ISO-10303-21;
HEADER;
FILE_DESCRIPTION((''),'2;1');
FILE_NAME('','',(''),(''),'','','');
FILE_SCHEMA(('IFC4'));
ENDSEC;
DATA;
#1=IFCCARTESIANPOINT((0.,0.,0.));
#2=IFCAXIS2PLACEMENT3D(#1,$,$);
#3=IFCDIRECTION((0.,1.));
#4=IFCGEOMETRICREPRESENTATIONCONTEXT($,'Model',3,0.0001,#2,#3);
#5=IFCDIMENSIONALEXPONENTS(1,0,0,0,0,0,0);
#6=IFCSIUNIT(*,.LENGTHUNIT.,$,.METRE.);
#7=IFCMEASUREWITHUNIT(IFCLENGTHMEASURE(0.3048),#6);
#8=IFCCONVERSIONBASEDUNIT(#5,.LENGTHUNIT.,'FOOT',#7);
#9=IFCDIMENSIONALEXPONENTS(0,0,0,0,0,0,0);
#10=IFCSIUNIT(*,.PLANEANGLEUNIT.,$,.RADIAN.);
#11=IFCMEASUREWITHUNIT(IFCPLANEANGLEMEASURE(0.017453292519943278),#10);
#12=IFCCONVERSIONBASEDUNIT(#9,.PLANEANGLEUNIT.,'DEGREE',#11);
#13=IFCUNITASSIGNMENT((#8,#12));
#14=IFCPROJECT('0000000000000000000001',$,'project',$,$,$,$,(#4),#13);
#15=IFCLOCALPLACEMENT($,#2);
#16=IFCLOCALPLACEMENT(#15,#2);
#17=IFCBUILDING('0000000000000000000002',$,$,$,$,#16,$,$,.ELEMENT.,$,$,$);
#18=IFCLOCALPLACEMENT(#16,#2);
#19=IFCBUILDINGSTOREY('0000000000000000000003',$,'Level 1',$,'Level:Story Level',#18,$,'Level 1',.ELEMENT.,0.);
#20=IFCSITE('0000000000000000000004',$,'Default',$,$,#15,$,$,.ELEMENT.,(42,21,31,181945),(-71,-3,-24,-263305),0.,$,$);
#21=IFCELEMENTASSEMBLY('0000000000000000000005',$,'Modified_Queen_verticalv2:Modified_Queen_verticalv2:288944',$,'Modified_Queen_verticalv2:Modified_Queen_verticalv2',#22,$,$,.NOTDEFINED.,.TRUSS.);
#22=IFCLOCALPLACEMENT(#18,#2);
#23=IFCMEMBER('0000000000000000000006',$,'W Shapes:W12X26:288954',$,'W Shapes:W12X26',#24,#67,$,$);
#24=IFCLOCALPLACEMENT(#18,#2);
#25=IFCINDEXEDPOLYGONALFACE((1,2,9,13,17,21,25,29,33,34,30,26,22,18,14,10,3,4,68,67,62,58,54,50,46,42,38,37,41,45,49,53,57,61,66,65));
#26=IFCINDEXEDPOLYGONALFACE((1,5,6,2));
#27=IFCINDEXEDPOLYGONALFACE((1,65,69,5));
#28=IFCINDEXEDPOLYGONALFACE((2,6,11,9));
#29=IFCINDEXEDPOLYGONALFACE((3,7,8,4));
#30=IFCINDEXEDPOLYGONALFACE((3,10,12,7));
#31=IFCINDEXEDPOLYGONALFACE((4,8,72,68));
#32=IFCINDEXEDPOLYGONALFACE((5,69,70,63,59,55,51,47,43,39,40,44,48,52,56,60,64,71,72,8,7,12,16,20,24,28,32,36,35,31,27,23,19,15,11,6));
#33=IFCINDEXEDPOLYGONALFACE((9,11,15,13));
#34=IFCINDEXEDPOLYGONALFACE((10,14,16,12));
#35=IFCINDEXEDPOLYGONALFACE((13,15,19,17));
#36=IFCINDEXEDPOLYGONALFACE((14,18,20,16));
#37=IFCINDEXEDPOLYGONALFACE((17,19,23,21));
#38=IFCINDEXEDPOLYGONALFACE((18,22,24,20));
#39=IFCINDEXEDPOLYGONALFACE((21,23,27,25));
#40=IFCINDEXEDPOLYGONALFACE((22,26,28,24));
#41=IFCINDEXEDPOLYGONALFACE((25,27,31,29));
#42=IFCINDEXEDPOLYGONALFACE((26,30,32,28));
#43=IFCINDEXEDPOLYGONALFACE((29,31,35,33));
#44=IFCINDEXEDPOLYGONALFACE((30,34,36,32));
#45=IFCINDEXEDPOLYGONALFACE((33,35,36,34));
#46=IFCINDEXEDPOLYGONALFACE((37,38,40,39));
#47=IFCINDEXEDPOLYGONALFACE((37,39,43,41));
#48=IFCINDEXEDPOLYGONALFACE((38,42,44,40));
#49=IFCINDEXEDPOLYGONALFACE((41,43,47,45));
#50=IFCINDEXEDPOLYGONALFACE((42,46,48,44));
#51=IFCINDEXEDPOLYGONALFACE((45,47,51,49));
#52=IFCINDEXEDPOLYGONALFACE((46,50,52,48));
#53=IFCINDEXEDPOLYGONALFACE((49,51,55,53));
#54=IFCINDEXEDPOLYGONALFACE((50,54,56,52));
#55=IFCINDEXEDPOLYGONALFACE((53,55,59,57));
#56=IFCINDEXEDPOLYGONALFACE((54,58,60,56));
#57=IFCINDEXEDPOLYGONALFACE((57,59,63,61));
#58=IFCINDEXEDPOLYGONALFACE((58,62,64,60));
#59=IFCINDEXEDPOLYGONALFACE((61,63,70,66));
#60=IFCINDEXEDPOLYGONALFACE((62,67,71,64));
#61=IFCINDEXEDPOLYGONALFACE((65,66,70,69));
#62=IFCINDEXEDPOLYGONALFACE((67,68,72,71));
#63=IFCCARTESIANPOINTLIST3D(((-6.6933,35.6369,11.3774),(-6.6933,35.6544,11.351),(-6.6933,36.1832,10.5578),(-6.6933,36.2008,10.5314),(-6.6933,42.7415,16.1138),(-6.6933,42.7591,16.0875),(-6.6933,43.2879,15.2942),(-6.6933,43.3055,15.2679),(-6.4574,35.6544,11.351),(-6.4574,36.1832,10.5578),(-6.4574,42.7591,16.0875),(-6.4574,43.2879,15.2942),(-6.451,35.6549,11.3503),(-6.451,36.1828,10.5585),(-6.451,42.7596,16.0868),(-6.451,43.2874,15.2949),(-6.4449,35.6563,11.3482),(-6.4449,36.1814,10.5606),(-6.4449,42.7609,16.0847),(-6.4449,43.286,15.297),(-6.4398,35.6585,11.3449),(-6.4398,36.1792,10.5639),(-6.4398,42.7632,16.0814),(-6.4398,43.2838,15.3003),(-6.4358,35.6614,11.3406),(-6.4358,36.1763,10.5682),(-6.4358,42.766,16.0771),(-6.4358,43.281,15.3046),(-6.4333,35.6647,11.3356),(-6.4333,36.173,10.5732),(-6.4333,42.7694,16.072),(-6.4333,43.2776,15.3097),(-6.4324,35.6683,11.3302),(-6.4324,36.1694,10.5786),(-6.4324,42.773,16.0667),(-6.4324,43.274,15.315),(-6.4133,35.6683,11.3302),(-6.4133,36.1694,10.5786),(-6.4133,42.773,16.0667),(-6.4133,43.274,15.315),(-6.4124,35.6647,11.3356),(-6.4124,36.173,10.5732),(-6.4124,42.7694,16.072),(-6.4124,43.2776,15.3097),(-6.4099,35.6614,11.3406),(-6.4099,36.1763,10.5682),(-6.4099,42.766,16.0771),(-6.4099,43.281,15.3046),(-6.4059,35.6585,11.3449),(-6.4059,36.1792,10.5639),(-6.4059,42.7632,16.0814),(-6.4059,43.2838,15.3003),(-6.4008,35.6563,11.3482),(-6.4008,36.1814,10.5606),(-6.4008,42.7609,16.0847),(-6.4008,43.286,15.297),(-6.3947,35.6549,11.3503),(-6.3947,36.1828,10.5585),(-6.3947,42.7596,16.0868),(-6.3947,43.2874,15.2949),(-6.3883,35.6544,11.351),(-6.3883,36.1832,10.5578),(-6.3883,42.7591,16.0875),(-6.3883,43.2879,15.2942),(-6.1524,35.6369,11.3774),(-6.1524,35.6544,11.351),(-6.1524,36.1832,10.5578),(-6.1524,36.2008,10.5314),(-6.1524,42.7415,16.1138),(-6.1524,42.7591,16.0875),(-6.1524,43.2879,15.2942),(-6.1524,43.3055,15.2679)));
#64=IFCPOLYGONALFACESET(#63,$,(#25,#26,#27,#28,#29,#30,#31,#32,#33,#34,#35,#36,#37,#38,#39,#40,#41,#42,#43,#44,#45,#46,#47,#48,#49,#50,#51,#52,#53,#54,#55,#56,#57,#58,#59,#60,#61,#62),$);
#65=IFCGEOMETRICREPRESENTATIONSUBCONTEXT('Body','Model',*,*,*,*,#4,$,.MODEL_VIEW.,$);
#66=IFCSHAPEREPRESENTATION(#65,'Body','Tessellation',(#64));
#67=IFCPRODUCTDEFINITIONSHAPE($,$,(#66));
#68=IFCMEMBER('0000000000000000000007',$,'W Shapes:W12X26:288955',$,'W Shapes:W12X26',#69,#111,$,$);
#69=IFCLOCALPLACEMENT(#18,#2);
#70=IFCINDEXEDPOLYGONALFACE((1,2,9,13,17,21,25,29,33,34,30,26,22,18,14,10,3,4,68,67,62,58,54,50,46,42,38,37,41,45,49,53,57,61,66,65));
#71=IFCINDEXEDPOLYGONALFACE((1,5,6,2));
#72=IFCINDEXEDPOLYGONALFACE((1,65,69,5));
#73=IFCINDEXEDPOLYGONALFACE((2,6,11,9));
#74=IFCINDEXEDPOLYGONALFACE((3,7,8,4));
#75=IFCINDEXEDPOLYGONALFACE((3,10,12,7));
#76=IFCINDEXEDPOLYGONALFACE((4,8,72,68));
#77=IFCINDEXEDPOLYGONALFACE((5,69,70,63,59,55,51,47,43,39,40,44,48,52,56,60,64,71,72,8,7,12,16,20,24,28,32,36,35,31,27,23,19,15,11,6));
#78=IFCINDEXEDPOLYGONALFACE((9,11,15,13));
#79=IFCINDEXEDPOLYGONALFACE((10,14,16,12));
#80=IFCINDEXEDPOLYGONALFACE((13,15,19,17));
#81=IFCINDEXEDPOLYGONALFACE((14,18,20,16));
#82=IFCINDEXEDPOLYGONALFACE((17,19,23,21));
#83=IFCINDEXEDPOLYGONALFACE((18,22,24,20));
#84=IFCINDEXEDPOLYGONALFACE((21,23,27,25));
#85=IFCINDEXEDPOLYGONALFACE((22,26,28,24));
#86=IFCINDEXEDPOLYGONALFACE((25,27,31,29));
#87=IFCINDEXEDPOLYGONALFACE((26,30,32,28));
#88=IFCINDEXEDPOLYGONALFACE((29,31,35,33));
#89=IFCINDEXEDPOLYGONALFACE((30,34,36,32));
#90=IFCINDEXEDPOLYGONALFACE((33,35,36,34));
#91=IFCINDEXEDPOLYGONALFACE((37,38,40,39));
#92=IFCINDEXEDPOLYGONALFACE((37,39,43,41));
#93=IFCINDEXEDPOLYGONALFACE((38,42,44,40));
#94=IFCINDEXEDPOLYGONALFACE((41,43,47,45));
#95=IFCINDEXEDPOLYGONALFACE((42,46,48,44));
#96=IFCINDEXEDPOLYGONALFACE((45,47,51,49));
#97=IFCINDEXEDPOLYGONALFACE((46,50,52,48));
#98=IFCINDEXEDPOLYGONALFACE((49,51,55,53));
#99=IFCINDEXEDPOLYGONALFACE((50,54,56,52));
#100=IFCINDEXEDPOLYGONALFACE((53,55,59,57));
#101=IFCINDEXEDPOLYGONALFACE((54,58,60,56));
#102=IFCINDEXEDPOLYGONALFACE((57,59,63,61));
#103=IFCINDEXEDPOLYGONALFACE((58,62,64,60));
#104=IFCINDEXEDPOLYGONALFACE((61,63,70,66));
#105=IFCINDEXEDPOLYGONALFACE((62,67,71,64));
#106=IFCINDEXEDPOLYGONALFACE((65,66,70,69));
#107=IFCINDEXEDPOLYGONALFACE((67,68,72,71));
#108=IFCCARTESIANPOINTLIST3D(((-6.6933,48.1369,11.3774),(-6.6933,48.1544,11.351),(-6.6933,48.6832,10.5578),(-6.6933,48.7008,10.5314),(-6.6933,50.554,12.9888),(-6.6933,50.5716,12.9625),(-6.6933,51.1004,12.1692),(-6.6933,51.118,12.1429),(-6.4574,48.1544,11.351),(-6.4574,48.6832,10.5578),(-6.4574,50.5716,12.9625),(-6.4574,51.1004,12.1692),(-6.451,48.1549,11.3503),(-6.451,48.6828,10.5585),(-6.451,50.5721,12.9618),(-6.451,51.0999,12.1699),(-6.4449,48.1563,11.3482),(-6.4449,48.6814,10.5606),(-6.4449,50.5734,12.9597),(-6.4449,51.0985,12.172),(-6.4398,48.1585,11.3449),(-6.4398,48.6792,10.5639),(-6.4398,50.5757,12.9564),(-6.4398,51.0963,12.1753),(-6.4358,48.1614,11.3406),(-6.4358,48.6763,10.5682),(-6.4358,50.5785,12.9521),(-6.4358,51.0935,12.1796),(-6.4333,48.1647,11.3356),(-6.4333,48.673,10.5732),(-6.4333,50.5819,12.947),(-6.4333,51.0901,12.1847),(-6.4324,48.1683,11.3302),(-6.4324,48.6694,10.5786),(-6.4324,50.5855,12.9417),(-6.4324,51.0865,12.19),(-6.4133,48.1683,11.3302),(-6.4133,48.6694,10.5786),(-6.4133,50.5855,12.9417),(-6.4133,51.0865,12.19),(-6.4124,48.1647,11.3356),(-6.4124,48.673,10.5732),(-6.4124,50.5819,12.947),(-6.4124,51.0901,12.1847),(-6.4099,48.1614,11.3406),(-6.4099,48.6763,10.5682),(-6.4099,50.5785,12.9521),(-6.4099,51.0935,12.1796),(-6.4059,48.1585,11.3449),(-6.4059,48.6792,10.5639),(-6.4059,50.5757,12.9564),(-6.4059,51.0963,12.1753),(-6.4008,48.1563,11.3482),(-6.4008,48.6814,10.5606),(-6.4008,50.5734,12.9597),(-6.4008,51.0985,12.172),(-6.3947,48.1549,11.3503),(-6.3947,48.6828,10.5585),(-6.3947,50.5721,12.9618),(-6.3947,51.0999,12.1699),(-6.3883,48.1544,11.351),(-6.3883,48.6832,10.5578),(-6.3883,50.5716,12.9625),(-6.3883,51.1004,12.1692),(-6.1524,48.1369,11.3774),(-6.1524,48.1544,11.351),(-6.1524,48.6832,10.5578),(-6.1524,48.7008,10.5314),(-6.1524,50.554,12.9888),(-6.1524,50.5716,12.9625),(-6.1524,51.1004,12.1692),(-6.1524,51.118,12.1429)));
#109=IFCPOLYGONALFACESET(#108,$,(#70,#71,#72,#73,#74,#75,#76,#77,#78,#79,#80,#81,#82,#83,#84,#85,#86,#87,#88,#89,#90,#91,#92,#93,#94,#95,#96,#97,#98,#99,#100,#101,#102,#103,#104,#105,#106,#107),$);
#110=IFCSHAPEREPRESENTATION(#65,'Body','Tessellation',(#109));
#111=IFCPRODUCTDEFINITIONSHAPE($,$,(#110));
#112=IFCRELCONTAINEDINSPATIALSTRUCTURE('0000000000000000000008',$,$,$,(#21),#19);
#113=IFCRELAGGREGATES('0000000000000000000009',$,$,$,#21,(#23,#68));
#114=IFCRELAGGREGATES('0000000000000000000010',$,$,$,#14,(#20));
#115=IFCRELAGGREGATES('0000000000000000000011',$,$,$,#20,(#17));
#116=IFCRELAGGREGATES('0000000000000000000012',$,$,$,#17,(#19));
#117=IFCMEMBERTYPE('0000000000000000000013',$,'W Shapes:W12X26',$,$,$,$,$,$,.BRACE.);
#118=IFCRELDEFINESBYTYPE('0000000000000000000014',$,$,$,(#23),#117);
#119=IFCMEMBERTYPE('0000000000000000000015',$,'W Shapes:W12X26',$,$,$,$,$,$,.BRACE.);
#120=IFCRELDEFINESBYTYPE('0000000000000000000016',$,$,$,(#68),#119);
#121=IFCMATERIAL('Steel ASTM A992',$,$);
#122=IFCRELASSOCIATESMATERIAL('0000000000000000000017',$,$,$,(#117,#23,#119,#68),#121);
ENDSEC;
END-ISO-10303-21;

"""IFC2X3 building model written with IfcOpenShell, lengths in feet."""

from ifc_helpers import new_model, entity, si_unit, converted_unit, direction, frame, frame_2d, origin, place, context, subcontext, project, spatial, polyline, circle_curve, parameter, trimmed, segment, composite_curve, outline, extrude, source, transform, mapped, material, type_object, type_shapes, element, aggregate, save


model = new_model("IFC2X3")

# Units and contexts
model_context = context("Model", 3, precision=0.0001, world=origin(), true_north=direction((0.0, 1.0)))
body_context = subcontext(model_context, "Body", "Model", "MODEL_VIEW")
ifc_project = project(units=[converted_unit("LENGTHUNIT", "FOOT", entity("IfcLengthMeasure", 0.3048), si_unit("LENGTHUNIT", "METRE"), dimensions=[1, 0, 0, 0, 0, 0, 0]), converted_unit("PLANEANGLEUNIT", "DEGREE", entity("IfcPlaneAngleMeasure", 0.017453292519943278), si_unit("PLANEANGLEUNIT", "RADIAN"), dimensions=[0, 0, 0, 0, 0, 0, 0])], contexts=[model_context])

# Site, building, storey
site_placement = place(None, origin())
site = spatial("IfcSite", under=ifc_project, at=site_placement, Name="Default", CompositionType="ELEMENT", RefLatitude=(42, 21, 31, 181945), RefLongitude=(-71, -3, -24, -263305), RefElevation=0.0)
building_placement = place(site_placement, origin())
building = spatial("IfcBuilding", under=site, at=building_placement, CompositionType="ELEMENT")
storey_placement = place(building_placement, origin())
storey = spatial("IfcBuildingStorey", under=building, at=storey_placement, Name="Level 1", ObjectType="Level:Story Level", LongName="Level 1", CompositionType="ELEMENT", Elevation=0.0)

# Element assembly, members
assembly_placement = place(storey_placement, origin())
assembly = element("IfcElementAssembly", 1, at=assembly_placement, inside=storey, Name="Modified_Queen_verticalv2:Modified_Queen_verticalv2:288944", ObjectType="Modified_Queen_verticalv2:Modified_Queen_verticalv2", AssemblyPlace="NOTDEFINED", PredefinedType="TRUSS")
ifc_material = material(Name="Steel ASTM A992")
member_type_1 = type_object("IfcMemberType", Name="W Shapes:W12X26", PredefinedType="BRACE", material=ifc_material)
shared_shape_1 = source(origin(), body_context, "Body", "SweptSolid", [
    extrude(outline(composite_curve([segment(polyline([(-0.2704, -0.4767), (-0.2704, -0.5083)]), True, "CONTINUOUS"), segment(polyline([(-0.2704, -0.5083), (0.2704, -0.5083)]), True, "CONTINUOUS"), segment(polyline([(0.2704, -0.5083), (0.2704, -0.4767)]), True, "CONTINUOUS"), segment(polyline([(0.2704, -0.4767), (0.0346, -0.4767)]), True, "CONTINUOUS"), segment(trimmed(circle_curve(frame_2d((0.0346, -0.4517), x_axis=(1.0, 0.0)), 0.025), [parameter(180.0)], [parameter(270.0)], True, "PARAMETER"), False, "CONTINUOUS"), segment(polyline([(0.0096, -0.4517), (0.0096, 0.4517)]), True, "CONTINUOUS"), segment(trimmed(circle_curve(frame_2d((0.0346, 0.4517), x_axis=(1.0, 0.0)), 0.025), [parameter(90.0)], [parameter(180.0)], True, "PARAMETER"), False, "CONTINUOUS"), segment(polyline([(0.0346, 0.4767), (0.2704, 0.4767)]), True, "CONTINUOUS"), segment(polyline([(0.2704, 0.4767), (0.2704, 0.5083)]), True, "CONTINUOUS"), segment(polyline([(0.2704, 0.5083), (-0.2704, 0.5083)]), True, "CONTINUOUS"), segment(polyline([(-0.2704, 0.5083), (-0.2704, 0.4767)]), True, "CONTINUOUS"), segment(polyline([(-0.2704, 0.4767), (-0.0346, 0.4767)]), True, "CONTINUOUS"), segment(trimmed(circle_curve(frame_2d((-0.0346, 0.4517), x_axis=(1.0, 0.0)), 0.025), [parameter(360.0)], [parameter(90.0)], True, "PARAMETER"), False, "CONTINUOUS"), segment(polyline([(-0.0096, 0.4517), (-0.0096, -0.4517)]), True, "CONTINUOUS"), segment(trimmed(circle_curve(frame_2d((-0.0346, -0.4517), x_axis=(1.0, 0.0)), 0.025), [parameter(270.0)], [parameter(360.0)], True, "PARAMETER"), False, "CONTINUOUS"), segment(polyline([(-0.0346, -0.4767), (-0.2704, -0.4767)]), True, "CONTINUOUS")], self_intersect=False)), frame((-3.9131, 0.0, 0.0), z_axis=(-1.0, 0.0, 0.0), x_axis=(0.0, -1.0, 0.0)), (0.0, 0.0, -1.0), 8.5387),
])
type_shapes(member_type_1, [shared_shape_1])
member_1_placement = place(assembly_placement, frame((-6.4228, 39.1747, 13.125), z_axis=(0.0, 0.5547, -0.83205), x_axis=(0.0, 0.83205, 0.5547)))
member_1 = element("IfcMember", 2, at=member_1_placement, type_object=member_type_1, material=ifc_material, Name="W Shapes:W12X26:288954", ObjectType="W Shapes:W12X26", context=body_context, shape_type="MappedRepresentation", body=[
    mapped(shared_shape_1, transform((0.0, 0.0, 0.0), scale=1.0)),
])
member_type_2 = type_object("IfcMemberType", Name="W Shapes:W12X26", PredefinedType="BRACE", material=ifc_material)
shared_shape_2 = source(origin(), body_context, "Body", "SweptSolid", [
    extrude(outline(composite_curve([segment(polyline([(-0.2704, -0.4767), (-0.2704, -0.5083)]), True, "CONTINUOUS"), segment(polyline([(-0.2704, -0.5083), (0.2704, -0.5083)]), True, "CONTINUOUS"), segment(polyline([(0.2704, -0.5083), (0.2704, -0.4767)]), True, "CONTINUOUS"), segment(polyline([(0.2704, -0.4767), (0.0346, -0.4767)]), True, "CONTINUOUS"), segment(trimmed(circle_curve(frame_2d((0.0346, -0.4517), x_axis=(0.0, -1.0)), 0.025), [parameter(270.0)], [parameter(360.0)], True, "PARAMETER"), False, "CONTINUOUS"), segment(polyline([(0.0096, -0.4517), (0.0096, 0.4517)]), True, "CONTINUOUS"), segment(trimmed(circle_curve(frame_2d((0.0346, 0.4517), x_axis=(-1.0, 0.0)), 0.025), [parameter(270.0)], [parameter(360.0)], True, "PARAMETER"), False, "CONTINUOUS"), segment(polyline([(0.0346, 0.4767), (0.2704, 0.4767)]), True, "CONTINUOUS"), segment(polyline([(0.2704, 0.4767), (0.2704, 0.5083)]), True, "CONTINUOUS"), segment(polyline([(0.2704, 0.5083), (-0.2704, 0.5083)]), True, "CONTINUOUS"), segment(polyline([(-0.2704, 0.5083), (-0.2704, 0.4767)]), True, "CONTINUOUS"), segment(polyline([(-0.2704, 0.4767), (-0.0346, 0.4767)]), True, "CONTINUOUS"), segment(trimmed(circle_curve(frame_2d((-0.0346, 0.4517), x_axis=(0.0, 1.0)), 0.025), [parameter(270.0)], [parameter(0.0)], True, "PARAMETER"), False, "CONTINUOUS"), segment(polyline([(-0.0096, 0.4517), (-0.0096, -0.4517)]), True, "CONTINUOUS"), segment(trimmed(circle_curve(frame_2d((-0.0346, -0.4517), x_axis=(1.0, 0.0)), 0.025), [parameter(270.0)], [parameter(0.0)], True, "PARAMETER"), False, "CONTINUOUS"), segment(polyline([(-0.0346, -0.4767), (-0.2704, -0.4767)]), True, "CONTINUOUS")], self_intersect=False)), frame((-1.0963, 0.0, 0.0), z_axis=(-1.0, 0.0, 0.0), x_axis=(0.0, -1.0, 0.0)), (0.0, 0.0, -1.0), 2.9051),
])
type_shapes(member_type_2, [shared_shape_2])
member_2_placement = place(assembly_placement, frame((-6.4228, 49.331, 11.5625), z_axis=(0.0, 0.5547, -0.83205), x_axis=(0.0, 0.83205, 0.5547)))
member_2 = element("IfcMember", 3, at=member_2_placement, type_object=member_type_2, material=ifc_material, Name="W Shapes:W12X26:288955", ObjectType="W Shapes:W12X26", context=body_context, shape_type="MappedRepresentation", body=[
    mapped(shared_shape_2, transform((0.0, 0.0, 0.0), scale=1.0)),
])
aggregate(assembly, [member_1, member_2])

save(model, "model.ifc")
